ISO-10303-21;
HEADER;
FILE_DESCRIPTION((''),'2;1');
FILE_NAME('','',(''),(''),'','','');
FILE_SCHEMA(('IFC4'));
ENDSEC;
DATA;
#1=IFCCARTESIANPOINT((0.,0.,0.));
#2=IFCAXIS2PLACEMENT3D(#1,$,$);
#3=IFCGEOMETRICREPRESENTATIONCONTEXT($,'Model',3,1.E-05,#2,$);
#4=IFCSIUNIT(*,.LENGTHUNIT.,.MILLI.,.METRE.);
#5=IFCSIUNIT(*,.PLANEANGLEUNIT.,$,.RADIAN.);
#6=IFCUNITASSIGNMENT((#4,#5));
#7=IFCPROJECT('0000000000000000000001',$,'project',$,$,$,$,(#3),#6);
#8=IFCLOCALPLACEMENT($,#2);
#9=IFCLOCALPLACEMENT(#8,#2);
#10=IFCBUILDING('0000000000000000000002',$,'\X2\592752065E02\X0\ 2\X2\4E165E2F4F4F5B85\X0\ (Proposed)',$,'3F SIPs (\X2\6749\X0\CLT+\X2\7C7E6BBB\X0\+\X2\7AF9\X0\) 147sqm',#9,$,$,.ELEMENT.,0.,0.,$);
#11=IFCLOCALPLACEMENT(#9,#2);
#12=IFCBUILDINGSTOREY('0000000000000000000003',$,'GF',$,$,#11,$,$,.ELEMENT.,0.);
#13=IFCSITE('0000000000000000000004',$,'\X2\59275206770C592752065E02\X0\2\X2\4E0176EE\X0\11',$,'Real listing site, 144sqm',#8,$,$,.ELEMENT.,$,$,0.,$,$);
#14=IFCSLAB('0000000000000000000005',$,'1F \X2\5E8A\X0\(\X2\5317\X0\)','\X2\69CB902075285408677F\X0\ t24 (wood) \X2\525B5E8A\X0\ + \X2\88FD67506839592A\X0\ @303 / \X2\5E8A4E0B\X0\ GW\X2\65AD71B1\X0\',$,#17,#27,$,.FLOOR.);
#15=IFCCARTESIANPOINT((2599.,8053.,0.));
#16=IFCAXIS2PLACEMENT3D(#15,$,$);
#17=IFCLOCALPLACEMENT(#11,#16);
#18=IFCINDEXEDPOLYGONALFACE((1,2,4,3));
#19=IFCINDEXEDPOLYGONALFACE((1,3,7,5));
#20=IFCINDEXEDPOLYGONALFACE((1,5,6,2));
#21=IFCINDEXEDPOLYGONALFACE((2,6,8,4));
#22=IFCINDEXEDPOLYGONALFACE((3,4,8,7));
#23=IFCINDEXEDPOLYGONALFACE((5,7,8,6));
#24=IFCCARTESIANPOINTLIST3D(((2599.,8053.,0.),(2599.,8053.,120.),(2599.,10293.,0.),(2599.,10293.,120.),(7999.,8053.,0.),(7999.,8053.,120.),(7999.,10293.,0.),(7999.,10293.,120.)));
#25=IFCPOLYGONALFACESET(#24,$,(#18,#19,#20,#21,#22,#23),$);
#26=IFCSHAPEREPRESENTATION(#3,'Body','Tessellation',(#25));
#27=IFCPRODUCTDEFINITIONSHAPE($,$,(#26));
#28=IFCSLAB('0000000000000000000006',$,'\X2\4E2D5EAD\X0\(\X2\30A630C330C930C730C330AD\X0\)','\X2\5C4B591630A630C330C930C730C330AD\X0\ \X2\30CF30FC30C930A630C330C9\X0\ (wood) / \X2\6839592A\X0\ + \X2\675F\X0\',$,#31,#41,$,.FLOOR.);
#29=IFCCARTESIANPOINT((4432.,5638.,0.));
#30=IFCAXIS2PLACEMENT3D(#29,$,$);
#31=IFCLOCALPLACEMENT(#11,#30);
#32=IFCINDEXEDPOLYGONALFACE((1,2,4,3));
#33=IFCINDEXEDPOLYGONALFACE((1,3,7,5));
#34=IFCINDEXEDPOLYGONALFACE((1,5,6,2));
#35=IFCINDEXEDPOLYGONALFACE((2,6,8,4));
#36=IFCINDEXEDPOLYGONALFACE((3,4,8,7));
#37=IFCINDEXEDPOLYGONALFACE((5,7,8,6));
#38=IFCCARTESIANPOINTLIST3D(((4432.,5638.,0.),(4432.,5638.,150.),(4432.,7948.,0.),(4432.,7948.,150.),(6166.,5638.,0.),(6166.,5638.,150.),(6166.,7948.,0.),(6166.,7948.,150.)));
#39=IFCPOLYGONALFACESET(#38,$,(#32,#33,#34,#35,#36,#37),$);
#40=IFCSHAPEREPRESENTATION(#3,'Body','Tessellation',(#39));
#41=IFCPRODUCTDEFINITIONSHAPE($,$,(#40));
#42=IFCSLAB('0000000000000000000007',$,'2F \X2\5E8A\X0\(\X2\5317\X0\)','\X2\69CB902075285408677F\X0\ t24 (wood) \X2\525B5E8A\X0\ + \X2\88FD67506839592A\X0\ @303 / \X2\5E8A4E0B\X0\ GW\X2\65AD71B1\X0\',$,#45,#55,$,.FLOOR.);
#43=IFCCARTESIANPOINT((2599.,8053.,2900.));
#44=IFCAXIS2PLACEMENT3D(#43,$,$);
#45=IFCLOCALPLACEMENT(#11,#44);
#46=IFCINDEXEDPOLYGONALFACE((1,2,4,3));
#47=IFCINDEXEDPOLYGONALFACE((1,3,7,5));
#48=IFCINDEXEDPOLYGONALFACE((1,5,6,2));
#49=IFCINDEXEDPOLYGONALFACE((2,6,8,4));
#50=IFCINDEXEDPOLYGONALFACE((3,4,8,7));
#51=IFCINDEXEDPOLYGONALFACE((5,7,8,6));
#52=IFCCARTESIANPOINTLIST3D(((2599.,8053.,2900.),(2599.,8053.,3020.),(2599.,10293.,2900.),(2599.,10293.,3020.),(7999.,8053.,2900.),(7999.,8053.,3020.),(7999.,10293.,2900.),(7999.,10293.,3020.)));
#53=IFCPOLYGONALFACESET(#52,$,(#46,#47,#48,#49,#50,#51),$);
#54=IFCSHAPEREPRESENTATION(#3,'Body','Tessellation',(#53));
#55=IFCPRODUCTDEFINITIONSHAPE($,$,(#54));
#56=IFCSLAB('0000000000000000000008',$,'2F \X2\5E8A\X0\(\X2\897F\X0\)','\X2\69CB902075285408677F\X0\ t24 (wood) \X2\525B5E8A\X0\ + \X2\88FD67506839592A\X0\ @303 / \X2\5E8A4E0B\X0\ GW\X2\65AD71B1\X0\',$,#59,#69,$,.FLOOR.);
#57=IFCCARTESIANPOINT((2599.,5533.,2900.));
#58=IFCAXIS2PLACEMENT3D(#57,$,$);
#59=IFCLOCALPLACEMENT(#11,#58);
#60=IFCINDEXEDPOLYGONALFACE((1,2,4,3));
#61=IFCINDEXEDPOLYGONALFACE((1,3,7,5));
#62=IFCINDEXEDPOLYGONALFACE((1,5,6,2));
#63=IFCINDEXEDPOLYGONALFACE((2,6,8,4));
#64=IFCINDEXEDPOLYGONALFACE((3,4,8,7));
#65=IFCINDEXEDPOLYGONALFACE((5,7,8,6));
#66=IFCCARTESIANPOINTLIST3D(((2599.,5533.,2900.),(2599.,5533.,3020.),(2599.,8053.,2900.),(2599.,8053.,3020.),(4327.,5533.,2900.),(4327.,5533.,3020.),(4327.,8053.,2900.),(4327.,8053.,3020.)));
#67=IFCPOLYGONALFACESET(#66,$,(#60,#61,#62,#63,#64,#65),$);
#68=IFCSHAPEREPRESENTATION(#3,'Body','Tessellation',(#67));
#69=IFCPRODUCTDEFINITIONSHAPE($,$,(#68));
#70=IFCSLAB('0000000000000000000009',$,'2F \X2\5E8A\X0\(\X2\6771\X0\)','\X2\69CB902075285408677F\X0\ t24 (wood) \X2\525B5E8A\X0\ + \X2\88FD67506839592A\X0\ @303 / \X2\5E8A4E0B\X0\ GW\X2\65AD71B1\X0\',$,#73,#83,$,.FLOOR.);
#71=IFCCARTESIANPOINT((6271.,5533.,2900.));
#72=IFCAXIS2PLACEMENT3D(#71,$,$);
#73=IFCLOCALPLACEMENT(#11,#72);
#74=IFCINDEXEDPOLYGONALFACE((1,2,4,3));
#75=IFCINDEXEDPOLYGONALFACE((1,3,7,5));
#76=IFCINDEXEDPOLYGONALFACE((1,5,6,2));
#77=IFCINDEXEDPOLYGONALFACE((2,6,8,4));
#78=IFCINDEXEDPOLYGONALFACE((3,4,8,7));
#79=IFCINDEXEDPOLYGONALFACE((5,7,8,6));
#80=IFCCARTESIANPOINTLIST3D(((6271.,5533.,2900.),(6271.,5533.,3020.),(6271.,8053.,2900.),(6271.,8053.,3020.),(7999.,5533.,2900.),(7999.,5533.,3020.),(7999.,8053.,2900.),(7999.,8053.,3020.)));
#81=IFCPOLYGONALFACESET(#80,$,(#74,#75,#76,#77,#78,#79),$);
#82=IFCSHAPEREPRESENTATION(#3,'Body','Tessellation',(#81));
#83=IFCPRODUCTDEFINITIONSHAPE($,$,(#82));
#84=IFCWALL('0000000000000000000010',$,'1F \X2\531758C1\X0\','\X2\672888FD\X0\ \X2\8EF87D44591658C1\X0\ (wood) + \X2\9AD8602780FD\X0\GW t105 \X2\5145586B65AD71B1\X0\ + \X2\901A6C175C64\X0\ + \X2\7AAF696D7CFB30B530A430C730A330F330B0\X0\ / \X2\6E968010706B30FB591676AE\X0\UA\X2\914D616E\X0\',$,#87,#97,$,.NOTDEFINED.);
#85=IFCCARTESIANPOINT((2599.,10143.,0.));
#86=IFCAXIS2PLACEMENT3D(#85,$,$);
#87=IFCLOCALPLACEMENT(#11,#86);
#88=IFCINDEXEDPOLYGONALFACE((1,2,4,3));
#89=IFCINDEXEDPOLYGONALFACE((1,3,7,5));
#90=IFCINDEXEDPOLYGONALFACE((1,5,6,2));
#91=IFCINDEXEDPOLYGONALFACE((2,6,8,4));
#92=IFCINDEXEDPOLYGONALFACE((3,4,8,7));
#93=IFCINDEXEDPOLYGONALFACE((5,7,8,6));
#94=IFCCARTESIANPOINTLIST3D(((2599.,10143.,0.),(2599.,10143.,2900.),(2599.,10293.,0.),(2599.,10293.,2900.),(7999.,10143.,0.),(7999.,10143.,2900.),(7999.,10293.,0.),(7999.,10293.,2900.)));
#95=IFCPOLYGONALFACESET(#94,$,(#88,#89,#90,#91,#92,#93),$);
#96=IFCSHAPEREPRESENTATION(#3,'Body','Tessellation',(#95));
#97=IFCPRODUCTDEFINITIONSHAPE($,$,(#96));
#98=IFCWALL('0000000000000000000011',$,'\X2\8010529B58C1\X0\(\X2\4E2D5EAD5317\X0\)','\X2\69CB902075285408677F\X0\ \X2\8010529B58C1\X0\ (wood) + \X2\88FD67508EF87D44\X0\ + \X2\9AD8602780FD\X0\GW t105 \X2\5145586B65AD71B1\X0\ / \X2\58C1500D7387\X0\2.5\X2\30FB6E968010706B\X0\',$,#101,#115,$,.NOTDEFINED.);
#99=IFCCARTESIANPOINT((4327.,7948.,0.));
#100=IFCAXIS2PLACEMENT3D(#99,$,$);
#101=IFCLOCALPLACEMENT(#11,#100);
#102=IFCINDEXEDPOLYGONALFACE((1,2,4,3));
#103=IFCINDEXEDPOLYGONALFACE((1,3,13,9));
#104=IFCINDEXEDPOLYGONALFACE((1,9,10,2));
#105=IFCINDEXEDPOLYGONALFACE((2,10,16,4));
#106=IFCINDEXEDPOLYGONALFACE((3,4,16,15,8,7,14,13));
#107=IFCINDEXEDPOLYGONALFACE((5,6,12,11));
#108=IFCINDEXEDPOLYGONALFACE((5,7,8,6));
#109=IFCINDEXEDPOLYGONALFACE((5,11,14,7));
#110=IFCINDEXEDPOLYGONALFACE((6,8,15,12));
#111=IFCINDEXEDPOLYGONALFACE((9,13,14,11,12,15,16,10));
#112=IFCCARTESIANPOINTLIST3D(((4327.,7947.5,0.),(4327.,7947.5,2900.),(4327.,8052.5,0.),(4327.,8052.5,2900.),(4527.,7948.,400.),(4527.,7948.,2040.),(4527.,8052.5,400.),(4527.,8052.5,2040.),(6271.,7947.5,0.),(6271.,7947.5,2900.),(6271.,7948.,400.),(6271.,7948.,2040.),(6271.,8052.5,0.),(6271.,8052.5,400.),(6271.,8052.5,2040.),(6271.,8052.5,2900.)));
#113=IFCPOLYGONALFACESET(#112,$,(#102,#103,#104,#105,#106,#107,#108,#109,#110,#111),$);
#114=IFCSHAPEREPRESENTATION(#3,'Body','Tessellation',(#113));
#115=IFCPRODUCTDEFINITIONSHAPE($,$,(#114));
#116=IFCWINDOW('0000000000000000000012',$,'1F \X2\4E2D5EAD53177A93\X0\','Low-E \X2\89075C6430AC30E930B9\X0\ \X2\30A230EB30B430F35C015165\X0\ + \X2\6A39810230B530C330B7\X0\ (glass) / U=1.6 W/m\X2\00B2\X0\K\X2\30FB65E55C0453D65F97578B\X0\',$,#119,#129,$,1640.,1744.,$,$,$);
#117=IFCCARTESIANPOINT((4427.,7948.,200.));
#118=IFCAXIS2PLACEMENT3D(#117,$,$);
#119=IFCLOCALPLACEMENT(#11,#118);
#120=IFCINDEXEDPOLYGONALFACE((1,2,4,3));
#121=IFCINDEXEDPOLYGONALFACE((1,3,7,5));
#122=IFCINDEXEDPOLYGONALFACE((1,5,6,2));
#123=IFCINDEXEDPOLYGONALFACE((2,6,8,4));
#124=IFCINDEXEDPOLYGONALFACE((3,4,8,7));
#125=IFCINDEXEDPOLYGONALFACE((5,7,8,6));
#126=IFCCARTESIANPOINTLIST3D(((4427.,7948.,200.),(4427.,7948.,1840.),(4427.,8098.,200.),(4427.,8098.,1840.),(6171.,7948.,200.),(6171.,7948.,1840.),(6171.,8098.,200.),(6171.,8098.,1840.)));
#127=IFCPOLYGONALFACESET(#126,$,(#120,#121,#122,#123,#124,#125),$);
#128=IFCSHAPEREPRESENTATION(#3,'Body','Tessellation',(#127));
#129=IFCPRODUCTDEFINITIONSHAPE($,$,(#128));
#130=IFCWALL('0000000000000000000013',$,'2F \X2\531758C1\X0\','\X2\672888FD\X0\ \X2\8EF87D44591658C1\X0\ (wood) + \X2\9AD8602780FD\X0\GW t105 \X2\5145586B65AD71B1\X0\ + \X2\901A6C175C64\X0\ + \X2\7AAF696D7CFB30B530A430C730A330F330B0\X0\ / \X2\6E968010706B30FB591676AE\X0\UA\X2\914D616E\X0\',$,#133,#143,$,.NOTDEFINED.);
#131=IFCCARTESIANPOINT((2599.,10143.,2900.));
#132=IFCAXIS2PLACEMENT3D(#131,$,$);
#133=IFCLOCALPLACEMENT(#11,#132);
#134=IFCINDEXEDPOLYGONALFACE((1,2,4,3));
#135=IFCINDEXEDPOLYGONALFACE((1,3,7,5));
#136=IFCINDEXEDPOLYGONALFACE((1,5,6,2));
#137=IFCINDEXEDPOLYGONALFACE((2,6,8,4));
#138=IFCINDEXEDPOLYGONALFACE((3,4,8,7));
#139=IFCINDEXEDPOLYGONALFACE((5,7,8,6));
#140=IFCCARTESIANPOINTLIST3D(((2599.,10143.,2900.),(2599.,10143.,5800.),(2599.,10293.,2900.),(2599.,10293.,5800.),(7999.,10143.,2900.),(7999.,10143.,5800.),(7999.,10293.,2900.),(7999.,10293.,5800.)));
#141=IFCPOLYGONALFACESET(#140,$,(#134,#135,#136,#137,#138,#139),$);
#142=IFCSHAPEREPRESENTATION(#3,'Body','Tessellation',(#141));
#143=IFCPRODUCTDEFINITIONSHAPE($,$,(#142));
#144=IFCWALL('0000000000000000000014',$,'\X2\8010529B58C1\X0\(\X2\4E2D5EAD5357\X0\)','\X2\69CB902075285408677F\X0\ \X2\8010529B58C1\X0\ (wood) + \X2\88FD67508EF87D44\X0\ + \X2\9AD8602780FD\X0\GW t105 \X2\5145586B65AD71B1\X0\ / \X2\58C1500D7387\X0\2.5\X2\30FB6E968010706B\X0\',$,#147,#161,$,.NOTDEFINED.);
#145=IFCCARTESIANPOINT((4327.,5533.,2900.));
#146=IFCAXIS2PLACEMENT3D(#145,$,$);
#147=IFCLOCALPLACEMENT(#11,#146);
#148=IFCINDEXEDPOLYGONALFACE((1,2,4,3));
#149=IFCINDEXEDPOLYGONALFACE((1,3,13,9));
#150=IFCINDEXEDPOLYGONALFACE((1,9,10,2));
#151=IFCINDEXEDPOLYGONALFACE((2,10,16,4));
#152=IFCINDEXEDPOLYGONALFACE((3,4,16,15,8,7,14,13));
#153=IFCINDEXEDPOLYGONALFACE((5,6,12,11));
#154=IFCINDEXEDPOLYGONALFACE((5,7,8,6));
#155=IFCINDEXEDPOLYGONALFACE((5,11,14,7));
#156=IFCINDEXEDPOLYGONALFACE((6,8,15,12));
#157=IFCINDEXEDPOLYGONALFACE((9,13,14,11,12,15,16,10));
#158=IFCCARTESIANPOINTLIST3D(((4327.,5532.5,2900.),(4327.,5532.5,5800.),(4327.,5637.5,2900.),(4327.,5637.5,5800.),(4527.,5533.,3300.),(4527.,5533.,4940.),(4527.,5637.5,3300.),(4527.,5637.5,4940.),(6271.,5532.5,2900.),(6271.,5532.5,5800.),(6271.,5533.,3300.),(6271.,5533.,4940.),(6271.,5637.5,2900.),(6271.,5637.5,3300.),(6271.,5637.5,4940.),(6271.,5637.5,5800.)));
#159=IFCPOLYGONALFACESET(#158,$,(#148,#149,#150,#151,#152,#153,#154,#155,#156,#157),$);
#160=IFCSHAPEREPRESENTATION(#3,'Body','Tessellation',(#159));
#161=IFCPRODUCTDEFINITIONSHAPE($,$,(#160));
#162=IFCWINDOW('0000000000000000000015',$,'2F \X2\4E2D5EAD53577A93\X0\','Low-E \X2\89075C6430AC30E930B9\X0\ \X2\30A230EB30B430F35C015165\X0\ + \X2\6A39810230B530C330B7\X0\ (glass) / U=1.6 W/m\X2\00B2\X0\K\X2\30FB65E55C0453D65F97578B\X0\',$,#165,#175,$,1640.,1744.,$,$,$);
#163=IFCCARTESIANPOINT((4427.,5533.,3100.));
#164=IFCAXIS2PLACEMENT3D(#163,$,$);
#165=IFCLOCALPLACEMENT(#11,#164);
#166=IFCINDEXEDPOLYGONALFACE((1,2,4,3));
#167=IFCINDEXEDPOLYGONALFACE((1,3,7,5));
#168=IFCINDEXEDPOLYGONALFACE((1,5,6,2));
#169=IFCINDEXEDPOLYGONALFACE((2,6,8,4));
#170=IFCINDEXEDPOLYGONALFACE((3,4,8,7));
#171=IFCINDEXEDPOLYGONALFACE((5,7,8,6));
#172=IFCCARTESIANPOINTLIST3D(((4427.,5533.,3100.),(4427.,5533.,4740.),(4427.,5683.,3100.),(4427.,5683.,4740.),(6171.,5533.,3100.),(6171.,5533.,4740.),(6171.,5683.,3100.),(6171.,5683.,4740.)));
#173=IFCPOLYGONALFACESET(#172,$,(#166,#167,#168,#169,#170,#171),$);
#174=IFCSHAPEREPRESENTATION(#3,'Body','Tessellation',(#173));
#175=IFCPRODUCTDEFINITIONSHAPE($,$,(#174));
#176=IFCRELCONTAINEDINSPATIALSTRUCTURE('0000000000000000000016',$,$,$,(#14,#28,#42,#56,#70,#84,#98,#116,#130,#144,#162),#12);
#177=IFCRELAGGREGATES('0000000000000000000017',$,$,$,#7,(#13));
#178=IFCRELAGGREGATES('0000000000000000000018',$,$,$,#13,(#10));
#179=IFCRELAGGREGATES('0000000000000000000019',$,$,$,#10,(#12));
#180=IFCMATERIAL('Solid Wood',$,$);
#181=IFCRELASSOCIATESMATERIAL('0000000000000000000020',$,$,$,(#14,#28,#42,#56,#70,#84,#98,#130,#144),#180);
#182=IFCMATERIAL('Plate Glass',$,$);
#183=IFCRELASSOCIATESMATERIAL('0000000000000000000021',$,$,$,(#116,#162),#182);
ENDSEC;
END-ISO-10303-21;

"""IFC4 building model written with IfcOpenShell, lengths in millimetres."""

from ifc_helpers import new_model, si_unit, frame, frame_2d, origin, place, context, project, spatial, rectangle, extrude, material, element, fill, save


model = new_model("IFC4")

# Units and contexts
model_context = context("Model", 3, precision=1e-05, world=origin())
ifc_project = project(units=[si_unit("LENGTHUNIT", "METRE", prefix="MILLI"), si_unit("PLANEANGLEUNIT", "RADIAN")], contexts=[model_context])

# Site, building, storey
site_placement = place(None, origin())
site = spatial("IfcSite", under=ifc_project, at=site_placement, Name="大分県大分市2丁目11", ObjectType="Real listing site, 144sqm", CompositionType="ELEMENT", RefElevation=0.0)
building_placement = place(site_placement, origin())
building = spatial("IfcBuilding", under=site, at=building_placement, Name="大分市 2世帯住宅 (Proposed)", ObjectType="3F SIPs (杉CLT+籾殻+竹) 147sqm", CompositionType="ELEMENT", ElevationOfRefHeight=0.0, ElevationOfTerrain=0.0)
storey_placement = place(building_placement, origin())
storey = spatial("IfcBuildingStorey", under=building, at=storey_placement, Name="GF", CompositionType="ELEMENT", Elevation=0.0)

# Slabs
ifc_material_1 = material(Name="Solid Wood")
slab_1_placement = place(storey_placement, frame((2599.0, 8053.0, 0.0)))
element("IfcSlab", 1, at=slab_1_placement, inside=storey, material=ifc_material_1, Name="1F 床(北)", Description="構造用合板 t24 (wood) 剛床 + 製材根太 @303 / 床下 GW断熱", PredefinedType="FLOOR", context=model_context, shape_type="SweptSolid", body=[
    extrude(rectangle(XDim=5400.0, YDim=2240.0, at=frame_2d((2700.0, 1120.0))), frame((2599.0, 8053.0, 0.0)), (0.0, 0.0, 1.0), 120.0),
])
slab_2_placement = place(storey_placement, frame((4432.0, 5638.0, 0.0)))
element("IfcSlab", 2, at=slab_2_placement, inside=storey, material=ifc_material_1, Name="中庭(ウッドデッキ)", Description="屋外ウッドデッキ ハードウッド (wood) / 根太 + 束", PredefinedType="FLOOR", context=model_context, shape_type="SweptSolid", body=[
    extrude(rectangle(XDim=1734.0, YDim=2310.0, at=frame_2d((867.0, 1155.0))), frame((4432.0, 5638.0, 0.0)), (0.0, 0.0, 1.0), 150.0),
])
slab_3_placement = place(storey_placement, frame((2599.0, 8053.0, 2900.0)))
element("IfcSlab", 3, at=slab_3_placement, inside=storey, material=ifc_material_1, Name="2F 床(北)", Description="構造用合板 t24 (wood) 剛床 + 製材根太 @303 / 床下 GW断熱", PredefinedType="FLOOR", context=model_context, shape_type="SweptSolid", body=[
    extrude(rectangle(XDim=5400.0, YDim=2240.0, at=frame_2d((2700.0, 1120.0))), frame((2599.0, 8053.0, 2900.0)), (0.0, 0.0, 1.0), 120.0),
])
slab_4_placement = place(storey_placement, frame((2599.0, 5533.0, 2900.0)))
element("IfcSlab", 4, at=slab_4_placement, inside=storey, material=ifc_material_1, Name="2F 床(西)", Description="構造用合板 t24 (wood) 剛床 + 製材根太 @303 / 床下 GW断熱", PredefinedType="FLOOR", context=model_context, shape_type="SweptSolid", body=[
    extrude(rectangle(XDim=1728.0, YDim=2520.0, at=frame_2d((864.0, 1260.0))), frame((2599.0, 5533.0, 2900.0)), (0.0, 0.0, 1.0), 120.0),
])
slab_5_placement = place(storey_placement, frame((6271.0, 5533.0, 2900.0)))
element("IfcSlab", 5, at=slab_5_placement, inside=storey, material=ifc_material_1, Name="2F 床(東)", Description="構造用合板 t24 (wood) 剛床 + 製材根太 @303 / 床下 GW断熱", PredefinedType="FLOOR", context=model_context, shape_type="SweptSolid", body=[
    extrude(rectangle(XDim=1728.0, YDim=2520.0, at=frame_2d((864.0, 1260.0))), frame((6271.0, 5533.0, 2900.0)), (0.0, 0.0, 1.0), 120.0),
])

# Wall
wall_1_placement = place(storey_placement, frame((2599.0, 10143.0, 0.0)))
element("IfcWall", 6, at=wall_1_placement, inside=storey, material=ifc_material_1, Name="1F 北壁", Description="木製 軸組外壁 (wood) + 高性能GW t105 充填断熱 + 通気層 + 窯業系サイディング / 準耐火・外皮UA配慮", PredefinedType="NOTDEFINED", context=model_context, shape_type="SweptSolid", body=[
    extrude(rectangle(XDim=5400.0, YDim=150.0, at=frame_2d((2700.0, 75.0))), frame((2599.0, 10143.0, 0.0)), (0.0, 0.0, 1.0), 2900.0),
])

# Wall, opening, window
wall_2_placement = place(storey_placement, frame((4327.0, 7948.0, 0.0)))
wall_2 = element("IfcWall", 7, at=wall_2_placement, inside=storey, material=ifc_material_1, Name="耐力壁(中庭北)", Description="構造用合板 耐力壁 (wood) + 製材軸組 + 高性能GW t105 充填断熱 / 壁倍率2.5・準耐火", PredefinedType="NOTDEFINED", context=model_context, shape_type="SweptSolid", body=[
    extrude(rectangle(XDim=1944.0, YDim=105.0, at=frame_2d((972.0, 52.0))), frame((4327.0, 7948.0, 0.0)), (0.0, 0.0, 1.0), 2900.0),
])
opening_1_placement = place(storey_placement, frame((4427.0, 7948.0, 200.0)))
opening_1 = element("IfcOpeningElement", 8, at=opening_1_placement, cuts=wall_2, PredefinedType="NOTDEFINED", context=model_context, shape_type="SweptSolid", body=[
    extrude(rectangle(XDim=1744.0, YDim=150.0, at=frame_2d((872.0, 75.0))), frame((4427.0, 7948.0, 200.0)), (0.0, 0.0, 1.0), 1640.0),
])
ifc_material_2 = material(Name="Plate Glass")
window_1_placement = place(storey_placement, frame((4427.0, 7948.0, 200.0)))
window_1 = element("IfcWindow", 9, at=window_1_placement, inside=storey, material=ifc_material_2, Name="1F 中庭北窓", Description="Low-E 複層ガラス アルゴン封入 + 樹脂サッシ (glass) / U=1.6 W/m²K・日射取得型", OverallHeight=1640.0, OverallWidth=1744.0, context=model_context, shape_type="SweptSolid", body=[
    extrude(rectangle(XDim=1744.0, YDim=150.0, at=frame_2d((872.0, 75.0))), frame((4427.0, 7948.0, 200.0)), (0.0, 0.0, 1.0), 1640.0),
])
fill(opening_1, window_1)

# Wall
wall_3_placement = place(storey_placement, frame((2599.0, 10143.0, 2900.0)))
element("IfcWall", 10, at=wall_3_placement, inside=storey, material=ifc_material_1, Name="2F 北壁", Description="木製 軸組外壁 (wood) + 高性能GW t105 充填断熱 + 通気層 + 窯業系サイディング / 準耐火・外皮UA配慮", PredefinedType="NOTDEFINED", context=model_context, shape_type="SweptSolid", body=[
    extrude(rectangle(XDim=5400.0, YDim=150.0, at=frame_2d((2700.0, 75.0))), frame((2599.0, 10143.0, 2900.0)), (0.0, 0.0, 1.0), 2900.0),
])

# Wall, opening, window
wall_4_placement = place(storey_placement, frame((4327.0, 5533.0, 2900.0)))
wall_4 = element("IfcWall", 11, at=wall_4_placement, inside=storey, material=ifc_material_1, Name="耐力壁(中庭南)", Description="構造用合板 耐力壁 (wood) + 製材軸組 + 高性能GW t105 充填断熱 / 壁倍率2.5・準耐火", PredefinedType="NOTDEFINED", context=model_context, shape_type="SweptSolid", body=[
    extrude(rectangle(XDim=1944.0, YDim=105.0, at=frame_2d((972.0, 52.0))), frame((4327.0, 5533.0, 2900.0)), (0.0, 0.0, 1.0), 2900.0),
])
opening_2_placement = place(storey_placement, frame((4427.0, 5533.0, 3100.0)))
opening_2 = element("IfcOpeningElement", 12, at=opening_2_placement, cuts=wall_4, PredefinedType="NOTDEFINED", context=model_context, shape_type="SweptSolid", body=[
    extrude(rectangle(XDim=1744.0, YDim=150.0, at=frame_2d((872.0, 75.0))), frame((4427.0, 5533.0, 3100.0)), (0.0, 0.0, 1.0), 1640.0),
])
window_2_placement = place(storey_placement, frame((4427.0, 5533.0, 3100.0)))
window_2 = element("IfcWindow", 13, at=window_2_placement, inside=storey, material=ifc_material_2, Name="2F 中庭南窓", Description="Low-E 複層ガラス アルゴン封入 + 樹脂サッシ (glass) / U=1.6 W/m²K・日射取得型", OverallHeight=1640.0, OverallWidth=1744.0, context=model_context, shape_type="SweptSolid", body=[
    extrude(rectangle(XDim=1744.0, YDim=150.0, at=frame_2d((872.0, 75.0))), frame((4427.0, 5533.0, 3100.0)), (0.0, 0.0, 1.0), 1640.0),
])
fill(opening_2, window_2)

save(model, "model.ifc")
